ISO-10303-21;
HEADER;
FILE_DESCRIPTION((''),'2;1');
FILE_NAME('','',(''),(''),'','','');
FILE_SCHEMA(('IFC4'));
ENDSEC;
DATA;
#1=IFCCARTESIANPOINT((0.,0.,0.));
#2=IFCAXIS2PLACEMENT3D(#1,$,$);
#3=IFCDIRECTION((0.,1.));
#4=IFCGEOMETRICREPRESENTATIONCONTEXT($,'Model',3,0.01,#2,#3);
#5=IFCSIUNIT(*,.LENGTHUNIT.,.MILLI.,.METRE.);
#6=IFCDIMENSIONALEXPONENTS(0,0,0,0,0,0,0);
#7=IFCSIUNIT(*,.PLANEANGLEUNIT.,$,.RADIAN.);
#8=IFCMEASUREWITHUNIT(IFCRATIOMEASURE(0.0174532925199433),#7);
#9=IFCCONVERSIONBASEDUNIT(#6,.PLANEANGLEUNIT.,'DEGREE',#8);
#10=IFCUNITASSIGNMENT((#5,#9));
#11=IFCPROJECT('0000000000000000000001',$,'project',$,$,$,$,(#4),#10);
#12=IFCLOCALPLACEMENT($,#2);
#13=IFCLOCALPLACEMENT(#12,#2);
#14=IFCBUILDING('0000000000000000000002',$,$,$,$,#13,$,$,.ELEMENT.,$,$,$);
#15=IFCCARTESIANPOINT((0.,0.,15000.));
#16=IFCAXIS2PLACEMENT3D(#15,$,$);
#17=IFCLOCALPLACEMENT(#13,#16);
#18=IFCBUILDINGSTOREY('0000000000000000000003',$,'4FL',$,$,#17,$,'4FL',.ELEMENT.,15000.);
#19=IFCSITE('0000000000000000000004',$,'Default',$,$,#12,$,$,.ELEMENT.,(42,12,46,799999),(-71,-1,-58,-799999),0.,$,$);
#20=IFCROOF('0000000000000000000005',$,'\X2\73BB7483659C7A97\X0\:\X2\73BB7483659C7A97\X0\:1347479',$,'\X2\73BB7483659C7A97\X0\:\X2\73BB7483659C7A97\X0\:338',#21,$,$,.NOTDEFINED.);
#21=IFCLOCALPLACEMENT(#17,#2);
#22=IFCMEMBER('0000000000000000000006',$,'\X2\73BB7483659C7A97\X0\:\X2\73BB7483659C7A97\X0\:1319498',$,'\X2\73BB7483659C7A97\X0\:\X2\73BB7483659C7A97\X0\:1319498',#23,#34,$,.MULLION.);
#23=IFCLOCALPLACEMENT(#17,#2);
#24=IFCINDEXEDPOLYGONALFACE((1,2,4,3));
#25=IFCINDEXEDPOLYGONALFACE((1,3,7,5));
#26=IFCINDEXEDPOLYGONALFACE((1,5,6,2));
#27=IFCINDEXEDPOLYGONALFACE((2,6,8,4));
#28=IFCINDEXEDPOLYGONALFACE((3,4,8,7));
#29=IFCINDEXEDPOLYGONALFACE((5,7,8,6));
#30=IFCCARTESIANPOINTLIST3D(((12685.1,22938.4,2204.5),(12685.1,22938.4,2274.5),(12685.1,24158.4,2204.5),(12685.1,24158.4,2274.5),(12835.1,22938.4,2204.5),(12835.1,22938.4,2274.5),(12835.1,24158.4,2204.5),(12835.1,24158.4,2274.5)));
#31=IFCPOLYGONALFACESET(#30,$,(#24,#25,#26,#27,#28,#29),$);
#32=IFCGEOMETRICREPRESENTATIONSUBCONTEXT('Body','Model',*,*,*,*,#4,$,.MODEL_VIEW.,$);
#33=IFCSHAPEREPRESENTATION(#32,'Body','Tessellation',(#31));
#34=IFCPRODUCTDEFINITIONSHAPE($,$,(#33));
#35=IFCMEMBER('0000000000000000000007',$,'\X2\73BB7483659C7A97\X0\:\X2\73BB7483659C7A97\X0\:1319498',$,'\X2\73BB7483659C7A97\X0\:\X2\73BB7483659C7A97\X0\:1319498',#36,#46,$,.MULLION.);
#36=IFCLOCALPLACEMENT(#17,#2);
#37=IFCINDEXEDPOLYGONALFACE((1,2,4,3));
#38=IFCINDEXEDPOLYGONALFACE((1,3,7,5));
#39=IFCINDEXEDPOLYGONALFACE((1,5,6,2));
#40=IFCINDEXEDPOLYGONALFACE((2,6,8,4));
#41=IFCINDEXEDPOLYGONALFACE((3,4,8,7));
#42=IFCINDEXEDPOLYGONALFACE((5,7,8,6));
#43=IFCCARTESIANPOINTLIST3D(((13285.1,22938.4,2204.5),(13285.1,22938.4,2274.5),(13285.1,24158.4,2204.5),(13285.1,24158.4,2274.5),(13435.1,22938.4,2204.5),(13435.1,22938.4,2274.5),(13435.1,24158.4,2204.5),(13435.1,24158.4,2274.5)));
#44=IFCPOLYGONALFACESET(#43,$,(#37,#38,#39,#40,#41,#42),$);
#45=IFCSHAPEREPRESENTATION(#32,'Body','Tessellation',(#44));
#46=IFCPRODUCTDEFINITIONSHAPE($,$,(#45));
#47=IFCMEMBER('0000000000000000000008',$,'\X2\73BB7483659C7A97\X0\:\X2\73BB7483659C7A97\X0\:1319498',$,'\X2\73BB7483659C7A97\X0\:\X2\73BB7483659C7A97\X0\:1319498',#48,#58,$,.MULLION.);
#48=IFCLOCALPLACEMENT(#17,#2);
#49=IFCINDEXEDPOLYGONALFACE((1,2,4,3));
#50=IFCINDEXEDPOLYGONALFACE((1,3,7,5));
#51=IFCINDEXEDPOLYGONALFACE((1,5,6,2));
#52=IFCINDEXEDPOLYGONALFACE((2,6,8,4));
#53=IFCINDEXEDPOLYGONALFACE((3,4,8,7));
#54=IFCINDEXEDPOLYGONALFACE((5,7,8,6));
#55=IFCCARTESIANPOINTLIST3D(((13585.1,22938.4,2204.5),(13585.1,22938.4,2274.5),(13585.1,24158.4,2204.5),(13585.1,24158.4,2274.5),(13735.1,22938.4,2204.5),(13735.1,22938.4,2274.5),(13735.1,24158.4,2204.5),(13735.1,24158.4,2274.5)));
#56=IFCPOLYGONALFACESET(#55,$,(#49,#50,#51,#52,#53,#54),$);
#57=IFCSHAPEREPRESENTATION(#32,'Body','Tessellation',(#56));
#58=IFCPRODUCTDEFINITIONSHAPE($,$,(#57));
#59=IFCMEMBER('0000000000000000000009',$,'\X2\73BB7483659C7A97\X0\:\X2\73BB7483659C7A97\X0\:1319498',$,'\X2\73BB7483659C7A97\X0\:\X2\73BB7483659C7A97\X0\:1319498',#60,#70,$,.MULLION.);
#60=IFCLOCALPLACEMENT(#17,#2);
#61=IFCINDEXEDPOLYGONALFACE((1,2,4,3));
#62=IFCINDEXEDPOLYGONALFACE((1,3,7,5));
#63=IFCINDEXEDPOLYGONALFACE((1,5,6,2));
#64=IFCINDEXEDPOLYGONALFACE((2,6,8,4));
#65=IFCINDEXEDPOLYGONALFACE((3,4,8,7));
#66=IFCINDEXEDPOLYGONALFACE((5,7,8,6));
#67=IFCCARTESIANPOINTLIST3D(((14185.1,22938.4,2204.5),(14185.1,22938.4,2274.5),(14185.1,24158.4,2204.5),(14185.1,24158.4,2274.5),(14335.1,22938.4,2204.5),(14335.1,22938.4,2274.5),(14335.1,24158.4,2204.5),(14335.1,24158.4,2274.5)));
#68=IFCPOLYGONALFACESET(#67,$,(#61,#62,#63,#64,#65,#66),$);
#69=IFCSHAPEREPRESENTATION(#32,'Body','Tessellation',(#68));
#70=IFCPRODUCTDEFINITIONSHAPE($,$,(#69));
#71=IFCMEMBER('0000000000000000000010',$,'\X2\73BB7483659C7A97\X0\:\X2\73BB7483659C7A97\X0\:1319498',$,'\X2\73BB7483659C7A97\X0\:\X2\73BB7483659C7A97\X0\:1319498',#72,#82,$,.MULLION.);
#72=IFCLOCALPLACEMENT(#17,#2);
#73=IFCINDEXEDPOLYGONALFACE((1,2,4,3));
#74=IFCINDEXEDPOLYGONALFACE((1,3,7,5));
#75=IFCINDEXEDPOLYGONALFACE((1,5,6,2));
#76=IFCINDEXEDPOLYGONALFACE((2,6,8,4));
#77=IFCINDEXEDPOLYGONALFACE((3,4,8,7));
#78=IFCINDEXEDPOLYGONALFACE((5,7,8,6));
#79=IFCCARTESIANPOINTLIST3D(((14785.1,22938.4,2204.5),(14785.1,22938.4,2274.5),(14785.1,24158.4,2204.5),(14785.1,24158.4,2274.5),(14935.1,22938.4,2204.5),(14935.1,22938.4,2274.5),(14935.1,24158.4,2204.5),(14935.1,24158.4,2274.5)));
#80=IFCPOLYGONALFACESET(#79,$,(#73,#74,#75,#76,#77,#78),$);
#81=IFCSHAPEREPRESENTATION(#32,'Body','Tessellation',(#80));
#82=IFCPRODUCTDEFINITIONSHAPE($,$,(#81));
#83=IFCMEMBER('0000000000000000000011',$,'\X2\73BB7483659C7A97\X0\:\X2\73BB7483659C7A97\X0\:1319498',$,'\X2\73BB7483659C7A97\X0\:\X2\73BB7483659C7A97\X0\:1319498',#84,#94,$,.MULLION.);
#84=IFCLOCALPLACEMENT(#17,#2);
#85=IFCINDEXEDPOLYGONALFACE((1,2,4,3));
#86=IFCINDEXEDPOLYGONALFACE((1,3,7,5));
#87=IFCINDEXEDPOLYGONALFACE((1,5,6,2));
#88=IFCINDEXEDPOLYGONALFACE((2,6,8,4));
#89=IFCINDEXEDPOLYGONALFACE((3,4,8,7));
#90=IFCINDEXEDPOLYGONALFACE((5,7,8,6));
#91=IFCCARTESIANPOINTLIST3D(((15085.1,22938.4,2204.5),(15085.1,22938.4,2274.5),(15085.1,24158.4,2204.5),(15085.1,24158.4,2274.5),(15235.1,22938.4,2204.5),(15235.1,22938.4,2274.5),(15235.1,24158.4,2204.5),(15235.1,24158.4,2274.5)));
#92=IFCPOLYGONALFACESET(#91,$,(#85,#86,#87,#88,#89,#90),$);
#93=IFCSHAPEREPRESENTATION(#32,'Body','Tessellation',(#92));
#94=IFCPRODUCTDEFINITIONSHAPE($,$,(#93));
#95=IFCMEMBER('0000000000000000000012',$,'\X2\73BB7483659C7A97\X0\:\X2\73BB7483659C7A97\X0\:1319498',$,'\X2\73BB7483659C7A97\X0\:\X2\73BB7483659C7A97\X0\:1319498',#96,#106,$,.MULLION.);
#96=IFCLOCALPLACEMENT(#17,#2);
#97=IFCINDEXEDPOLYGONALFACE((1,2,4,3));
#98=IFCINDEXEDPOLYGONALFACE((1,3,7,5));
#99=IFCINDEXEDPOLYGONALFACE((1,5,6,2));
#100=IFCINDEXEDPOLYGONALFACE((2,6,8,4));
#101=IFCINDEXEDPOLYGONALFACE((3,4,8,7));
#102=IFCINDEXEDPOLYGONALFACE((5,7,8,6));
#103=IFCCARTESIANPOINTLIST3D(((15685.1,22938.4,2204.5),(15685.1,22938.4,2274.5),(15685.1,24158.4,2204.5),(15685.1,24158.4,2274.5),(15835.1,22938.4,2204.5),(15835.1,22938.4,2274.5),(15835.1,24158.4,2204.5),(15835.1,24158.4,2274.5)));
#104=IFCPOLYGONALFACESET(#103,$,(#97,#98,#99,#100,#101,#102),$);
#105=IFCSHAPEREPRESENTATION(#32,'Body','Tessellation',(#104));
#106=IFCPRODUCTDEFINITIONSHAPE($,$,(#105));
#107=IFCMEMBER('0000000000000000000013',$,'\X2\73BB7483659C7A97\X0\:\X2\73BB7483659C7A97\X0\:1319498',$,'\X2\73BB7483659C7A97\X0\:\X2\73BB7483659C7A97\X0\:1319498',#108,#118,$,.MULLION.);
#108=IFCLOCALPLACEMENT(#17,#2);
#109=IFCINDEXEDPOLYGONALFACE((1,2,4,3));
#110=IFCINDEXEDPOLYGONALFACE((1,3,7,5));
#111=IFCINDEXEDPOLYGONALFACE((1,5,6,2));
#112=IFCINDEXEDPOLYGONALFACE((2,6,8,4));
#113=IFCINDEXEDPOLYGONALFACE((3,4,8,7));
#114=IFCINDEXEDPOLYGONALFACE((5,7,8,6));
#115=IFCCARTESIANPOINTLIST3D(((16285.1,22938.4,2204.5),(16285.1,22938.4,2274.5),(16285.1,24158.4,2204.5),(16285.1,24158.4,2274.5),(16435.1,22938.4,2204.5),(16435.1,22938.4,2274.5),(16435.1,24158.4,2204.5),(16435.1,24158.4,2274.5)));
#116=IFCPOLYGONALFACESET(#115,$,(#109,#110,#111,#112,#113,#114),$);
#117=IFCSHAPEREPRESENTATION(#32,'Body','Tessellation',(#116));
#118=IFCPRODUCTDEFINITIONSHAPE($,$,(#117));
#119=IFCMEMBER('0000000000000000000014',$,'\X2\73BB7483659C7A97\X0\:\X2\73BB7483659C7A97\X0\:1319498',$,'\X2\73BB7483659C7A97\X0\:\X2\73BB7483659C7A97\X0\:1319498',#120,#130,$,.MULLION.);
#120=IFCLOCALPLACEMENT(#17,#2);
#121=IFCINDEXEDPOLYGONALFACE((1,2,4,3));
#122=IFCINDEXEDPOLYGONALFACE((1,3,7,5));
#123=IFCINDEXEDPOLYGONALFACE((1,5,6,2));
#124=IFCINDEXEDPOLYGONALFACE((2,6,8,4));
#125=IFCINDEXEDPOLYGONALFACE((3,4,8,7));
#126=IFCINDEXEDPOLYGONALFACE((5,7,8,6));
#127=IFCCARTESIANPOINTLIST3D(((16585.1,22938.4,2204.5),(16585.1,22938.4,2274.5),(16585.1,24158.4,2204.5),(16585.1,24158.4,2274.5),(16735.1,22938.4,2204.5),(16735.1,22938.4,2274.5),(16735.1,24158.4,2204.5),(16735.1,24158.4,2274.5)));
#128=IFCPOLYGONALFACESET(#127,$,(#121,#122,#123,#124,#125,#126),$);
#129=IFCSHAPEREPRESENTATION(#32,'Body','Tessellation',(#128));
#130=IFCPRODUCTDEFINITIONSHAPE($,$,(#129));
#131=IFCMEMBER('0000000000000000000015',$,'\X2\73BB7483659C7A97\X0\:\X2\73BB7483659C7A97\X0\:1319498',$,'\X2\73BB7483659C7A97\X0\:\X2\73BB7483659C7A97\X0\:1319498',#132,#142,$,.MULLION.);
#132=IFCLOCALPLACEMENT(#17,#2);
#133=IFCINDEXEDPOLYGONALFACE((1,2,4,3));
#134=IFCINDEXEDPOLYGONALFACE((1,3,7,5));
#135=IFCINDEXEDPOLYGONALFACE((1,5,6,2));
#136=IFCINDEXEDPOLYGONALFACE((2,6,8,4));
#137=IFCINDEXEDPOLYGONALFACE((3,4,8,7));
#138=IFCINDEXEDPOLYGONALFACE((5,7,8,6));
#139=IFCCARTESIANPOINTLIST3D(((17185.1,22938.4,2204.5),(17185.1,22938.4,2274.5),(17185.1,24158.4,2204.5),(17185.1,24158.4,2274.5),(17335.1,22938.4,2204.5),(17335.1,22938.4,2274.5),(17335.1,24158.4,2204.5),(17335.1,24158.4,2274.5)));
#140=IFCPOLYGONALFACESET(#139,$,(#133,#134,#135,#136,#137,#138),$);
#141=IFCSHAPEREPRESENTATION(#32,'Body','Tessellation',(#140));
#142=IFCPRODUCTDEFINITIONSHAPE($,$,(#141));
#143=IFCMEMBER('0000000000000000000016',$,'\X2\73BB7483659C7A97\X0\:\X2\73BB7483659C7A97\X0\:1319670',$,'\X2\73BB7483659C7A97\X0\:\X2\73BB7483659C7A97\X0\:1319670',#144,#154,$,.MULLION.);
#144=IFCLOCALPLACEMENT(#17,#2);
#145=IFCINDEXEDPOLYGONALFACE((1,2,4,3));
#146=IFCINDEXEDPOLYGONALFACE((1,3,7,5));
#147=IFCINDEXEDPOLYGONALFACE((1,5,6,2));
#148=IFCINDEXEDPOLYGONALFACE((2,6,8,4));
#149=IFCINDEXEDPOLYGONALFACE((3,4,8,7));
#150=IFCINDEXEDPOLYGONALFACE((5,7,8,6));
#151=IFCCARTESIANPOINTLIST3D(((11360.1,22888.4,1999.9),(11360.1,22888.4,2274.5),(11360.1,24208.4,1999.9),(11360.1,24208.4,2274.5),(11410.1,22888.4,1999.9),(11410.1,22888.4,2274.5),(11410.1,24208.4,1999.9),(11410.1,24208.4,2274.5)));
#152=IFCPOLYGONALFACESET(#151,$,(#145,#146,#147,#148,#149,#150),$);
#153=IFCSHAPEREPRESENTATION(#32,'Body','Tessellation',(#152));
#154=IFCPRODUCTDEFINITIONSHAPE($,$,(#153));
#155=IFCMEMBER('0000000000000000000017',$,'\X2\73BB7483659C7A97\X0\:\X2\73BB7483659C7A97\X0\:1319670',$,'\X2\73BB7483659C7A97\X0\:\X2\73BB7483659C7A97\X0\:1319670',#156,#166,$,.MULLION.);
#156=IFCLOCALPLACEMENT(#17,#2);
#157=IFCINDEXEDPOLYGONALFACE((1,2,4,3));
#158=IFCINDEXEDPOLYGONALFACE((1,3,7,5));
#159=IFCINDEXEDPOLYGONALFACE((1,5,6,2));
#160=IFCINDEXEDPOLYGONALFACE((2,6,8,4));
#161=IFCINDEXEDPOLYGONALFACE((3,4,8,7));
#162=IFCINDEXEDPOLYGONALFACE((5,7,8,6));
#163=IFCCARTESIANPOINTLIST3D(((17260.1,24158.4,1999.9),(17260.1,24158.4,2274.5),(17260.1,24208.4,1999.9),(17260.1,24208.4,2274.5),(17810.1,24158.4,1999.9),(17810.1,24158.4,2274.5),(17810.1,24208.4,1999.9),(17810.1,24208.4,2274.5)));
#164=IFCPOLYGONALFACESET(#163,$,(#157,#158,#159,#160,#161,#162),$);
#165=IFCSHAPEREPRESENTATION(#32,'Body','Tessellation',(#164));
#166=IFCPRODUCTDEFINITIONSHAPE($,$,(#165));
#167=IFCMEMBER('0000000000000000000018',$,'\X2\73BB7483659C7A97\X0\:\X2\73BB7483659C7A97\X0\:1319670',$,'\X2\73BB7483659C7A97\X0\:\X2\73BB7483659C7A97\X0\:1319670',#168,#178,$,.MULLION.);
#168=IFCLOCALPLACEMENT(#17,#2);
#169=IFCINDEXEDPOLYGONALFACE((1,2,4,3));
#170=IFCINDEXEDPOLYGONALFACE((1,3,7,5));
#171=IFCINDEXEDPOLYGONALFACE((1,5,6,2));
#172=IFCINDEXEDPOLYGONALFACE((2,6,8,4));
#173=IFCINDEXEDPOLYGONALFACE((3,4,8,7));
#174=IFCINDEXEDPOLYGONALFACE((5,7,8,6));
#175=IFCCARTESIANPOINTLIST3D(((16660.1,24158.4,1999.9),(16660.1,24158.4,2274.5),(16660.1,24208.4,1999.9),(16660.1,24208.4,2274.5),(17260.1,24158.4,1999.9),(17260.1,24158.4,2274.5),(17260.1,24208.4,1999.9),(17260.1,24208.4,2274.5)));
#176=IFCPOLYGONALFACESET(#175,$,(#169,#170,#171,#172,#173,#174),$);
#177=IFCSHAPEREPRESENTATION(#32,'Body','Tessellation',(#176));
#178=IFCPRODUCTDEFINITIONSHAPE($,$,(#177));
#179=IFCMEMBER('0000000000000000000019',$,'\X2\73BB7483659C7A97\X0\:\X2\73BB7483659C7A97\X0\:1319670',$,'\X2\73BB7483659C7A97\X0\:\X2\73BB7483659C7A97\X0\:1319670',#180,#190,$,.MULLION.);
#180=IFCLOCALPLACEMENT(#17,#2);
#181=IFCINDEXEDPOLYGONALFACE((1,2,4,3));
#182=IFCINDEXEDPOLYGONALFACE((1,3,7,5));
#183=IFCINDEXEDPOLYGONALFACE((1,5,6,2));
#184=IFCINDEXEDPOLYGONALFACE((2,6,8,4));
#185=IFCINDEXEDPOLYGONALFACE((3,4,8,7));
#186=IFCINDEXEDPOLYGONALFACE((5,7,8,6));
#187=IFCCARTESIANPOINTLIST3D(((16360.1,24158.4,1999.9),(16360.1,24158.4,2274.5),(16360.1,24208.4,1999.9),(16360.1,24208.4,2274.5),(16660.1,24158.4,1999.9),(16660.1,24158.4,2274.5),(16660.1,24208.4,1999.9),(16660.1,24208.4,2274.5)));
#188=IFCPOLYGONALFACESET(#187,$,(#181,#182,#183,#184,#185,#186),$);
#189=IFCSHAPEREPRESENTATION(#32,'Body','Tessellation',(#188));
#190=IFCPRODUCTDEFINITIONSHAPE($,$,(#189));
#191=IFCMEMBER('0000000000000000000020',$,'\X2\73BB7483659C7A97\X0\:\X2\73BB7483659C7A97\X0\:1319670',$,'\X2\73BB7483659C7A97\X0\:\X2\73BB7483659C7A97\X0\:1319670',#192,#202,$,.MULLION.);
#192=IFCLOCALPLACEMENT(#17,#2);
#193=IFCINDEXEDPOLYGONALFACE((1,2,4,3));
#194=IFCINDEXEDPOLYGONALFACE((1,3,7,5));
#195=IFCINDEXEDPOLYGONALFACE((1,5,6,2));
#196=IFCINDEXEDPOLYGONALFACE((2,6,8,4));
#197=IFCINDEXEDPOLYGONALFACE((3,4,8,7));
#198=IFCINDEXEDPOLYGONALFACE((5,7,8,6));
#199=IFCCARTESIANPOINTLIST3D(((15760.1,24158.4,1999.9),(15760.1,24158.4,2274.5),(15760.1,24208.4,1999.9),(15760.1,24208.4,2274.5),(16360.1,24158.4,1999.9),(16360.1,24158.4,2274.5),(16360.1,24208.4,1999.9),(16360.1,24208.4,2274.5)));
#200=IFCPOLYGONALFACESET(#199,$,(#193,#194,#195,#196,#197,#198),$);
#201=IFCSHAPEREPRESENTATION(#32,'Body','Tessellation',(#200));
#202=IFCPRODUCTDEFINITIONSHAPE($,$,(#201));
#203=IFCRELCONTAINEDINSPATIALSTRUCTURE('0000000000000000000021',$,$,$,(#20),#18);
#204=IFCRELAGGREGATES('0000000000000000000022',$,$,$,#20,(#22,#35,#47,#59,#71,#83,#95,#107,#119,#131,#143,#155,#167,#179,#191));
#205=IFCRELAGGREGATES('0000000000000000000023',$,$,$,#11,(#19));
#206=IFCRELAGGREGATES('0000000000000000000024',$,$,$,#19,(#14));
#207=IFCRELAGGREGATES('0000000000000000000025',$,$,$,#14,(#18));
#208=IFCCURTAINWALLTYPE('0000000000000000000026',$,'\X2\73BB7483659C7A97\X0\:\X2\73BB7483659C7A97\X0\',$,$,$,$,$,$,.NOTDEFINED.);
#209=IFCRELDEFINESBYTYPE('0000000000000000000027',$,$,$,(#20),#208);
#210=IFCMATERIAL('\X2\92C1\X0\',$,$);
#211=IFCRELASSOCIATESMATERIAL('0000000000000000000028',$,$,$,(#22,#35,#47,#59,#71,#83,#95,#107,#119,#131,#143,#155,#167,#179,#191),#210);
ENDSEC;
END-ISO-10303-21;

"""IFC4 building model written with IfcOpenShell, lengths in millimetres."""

from ifc_helpers import new_model, entity, si_unit, converted_unit, direction, frame, frame_2d, origin, place, context, subcontext, project, spatial, rectangle, extrude, material, type_object, element, aggregate, save


model = new_model("IFC4")

# Units and contexts
model_context = context("Model", 3, precision=0.01, world=origin(), true_north=direction((0.0, 1.0)))
body_context = subcontext(model_context, "Body", "Model", "MODEL_VIEW")
ifc_project = project(units=[si_unit("LENGTHUNIT", "METRE", prefix="MILLI"), converted_unit("PLANEANGLEUNIT", "DEGREE", entity("IfcRatioMeasure", 0.0174532925199433), si_unit("PLANEANGLEUNIT", "RADIAN"), dimensions=[0, 0, 0, 0, 0, 0, 0])], contexts=[model_context])

# Site, building, storey
site_placement = place(None, origin())
site = spatial("IfcSite", under=ifc_project, at=site_placement, Name="Default", CompositionType="ELEMENT", RefLatitude=(42, 12, 46, 799999), RefLongitude=(-71, -1, -58, -799999), RefElevation=0.0)
building_placement = place(site_placement, origin())
building = spatial("IfcBuilding", under=site, at=building_placement, CompositionType="ELEMENT")
storey_placement = place(building_placement, frame((0.0, 0.0, 15000.0)))
storey = spatial("IfcBuildingStorey", under=building, at=storey_placement, Name="4FL", LongName="4FL", CompositionType="ELEMENT", Elevation=15000.0)

# Roof, members
curtain_wall_type = type_object("IfcCurtainWallType", Name="玻璃斜窗:玻璃斜窗", PredefinedType="NOTDEFINED")
roof_1_placement = place(storey_placement, frame((0.0, 0.0, -15000.0)))
roof_1 = element("IfcRoof", 1, at=roof_1_placement, inside=storey, type_object=curtain_wall_type, Name="玻璃斜窗:玻璃斜窗:1347479", ObjectType="玻璃斜窗:玻璃斜窗:338", PredefinedType="NOTDEFINED")
ifc_material = material(Name="鋁")
member_1_placement = place(roof_1_placement, frame((0.0, 0.0, 15000.0)))
member_1 = element("IfcMember", 2, at=member_1_placement, material=ifc_material, Name="玻璃斜窗:玻璃斜窗:1319498", ObjectType="玻璃斜窗:玻璃斜窗:1319498", PredefinedType="MULLION", context=body_context, shape_type="SweptSolid", body=[
    extrude(rectangle(XDim=70.0, YDim=150.0, at=frame_2d((0.0, 0.0), x_axis=(1.0, 0.0))), frame((12760.1, 22938.4, 2239.5), z_axis=(0.0, 1.0, 0.0), x_axis=(0.0, 0.0, -1.0)), (0.0, 0.0, 1.0), 1220.0),
])
member_2_placement = place(roof_1_placement, frame((0.0, 0.0, 15000.0)))
member_2 = element("IfcMember", 3, at=member_2_placement, material=ifc_material, Name="玻璃斜窗:玻璃斜窗:1319498", ObjectType="玻璃斜窗:玻璃斜窗:1319498", PredefinedType="MULLION", context=body_context, shape_type="SweptSolid", body=[
    extrude(rectangle(XDim=70.0, YDim=150.0, at=frame_2d((0.0, 0.0), x_axis=(1.0, 0.0))), frame((13360.1, 22938.4, 2239.5), z_axis=(0.0, 1.0, 0.0), x_axis=(0.0, 0.0, -1.0)), (0.0, 0.0, 1.0), 1220.0),
])
member_3_placement = place(roof_1_placement, frame((0.0, 0.0, 15000.0)))
member_3 = element("IfcMember", 4, at=member_3_placement, material=ifc_material, Name="玻璃斜窗:玻璃斜窗:1319498", ObjectType="玻璃斜窗:玻璃斜窗:1319498", PredefinedType="MULLION", context=body_context, shape_type="SweptSolid", body=[
    extrude(rectangle(XDim=70.0, YDim=150.0, at=frame_2d((0.0, 0.0), x_axis=(1.0, 0.0))), frame((13660.1, 22938.4, 2239.5), z_axis=(0.0, 1.0, 0.0), x_axis=(0.0, 0.0, -1.0)), (0.0, 0.0, 1.0), 1220.0),
])
member_4_placement = place(roof_1_placement, frame((0.0, 0.0, 15000.0)))
member_4 = element("IfcMember", 5, at=member_4_placement, material=ifc_material, Name="玻璃斜窗:玻璃斜窗:1319498", ObjectType="玻璃斜窗:玻璃斜窗:1319498", PredefinedType="MULLION", context=body_context, shape_type="SweptSolid", body=[
    extrude(rectangle(XDim=70.0, YDim=150.0, at=frame_2d((0.0, 0.0), x_axis=(1.0, 0.0))), frame((14260.1, 22938.4, 2239.5), z_axis=(0.0, 1.0, 0.0), x_axis=(0.0, 0.0, -1.0)), (0.0, 0.0, 1.0), 1220.0),
])
member_5_placement = place(roof_1_placement, frame((0.0, 0.0, 15000.0)))
member_5 = element("IfcMember", 6, at=member_5_placement, material=ifc_material, Name="玻璃斜窗:玻璃斜窗:1319498", ObjectType="玻璃斜窗:玻璃斜窗:1319498", PredefinedType="MULLION", context=body_context, shape_type="SweptSolid", body=[
    extrude(rectangle(XDim=70.0, YDim=150.0, at=frame_2d((0.0, 0.0), x_axis=(1.0, 0.0))), frame((14860.1, 22938.4, 2239.5), z_axis=(0.0, 1.0, 0.0), x_axis=(0.0, 0.0, -1.0)), (0.0, 0.0, 1.0), 1220.0),
])
member_6_placement = place(roof_1_placement, frame((0.0, 0.0, 15000.0)))
member_6 = element("IfcMember", 7, at=member_6_placement, material=ifc_material, Name="玻璃斜窗:玻璃斜窗:1319498", ObjectType="玻璃斜窗:玻璃斜窗:1319498", PredefinedType="MULLION", context=body_context, shape_type="SweptSolid", body=[
    extrude(rectangle(XDim=70.0, YDim=150.0, at=frame_2d((0.0, 0.0), x_axis=(1.0, 0.0))), frame((15160.1, 22938.4, 2239.5), z_axis=(0.0, 1.0, 0.0), x_axis=(0.0, 0.0, -1.0)), (0.0, 0.0, 1.0), 1220.0),
])
member_7_placement = place(roof_1_placement, frame((0.0, 0.0, 15000.0)))
member_7 = element("IfcMember", 8, at=member_7_placement, material=ifc_material, Name="玻璃斜窗:玻璃斜窗:1319498", ObjectType="玻璃斜窗:玻璃斜窗:1319498", PredefinedType="MULLION", context=body_context, shape_type="SweptSolid", body=[
    extrude(rectangle(XDim=70.0, YDim=150.0, at=frame_2d((0.0, 0.0), x_axis=(1.0, 0.0))), frame((15760.1, 22938.4, 2239.5), z_axis=(0.0, 1.0, 0.0), x_axis=(0.0, 0.0, -1.0)), (0.0, 0.0, 1.0), 1220.0),
])
member_8_placement = place(roof_1_placement, frame((0.0, 0.0, 15000.0)))
member_8 = element("IfcMember", 9, at=member_8_placement, material=ifc_material, Name="玻璃斜窗:玻璃斜窗:1319498", ObjectType="玻璃斜窗:玻璃斜窗:1319498", PredefinedType="MULLION", context=body_context, shape_type="SweptSolid", body=[
    extrude(rectangle(XDim=70.0, YDim=150.0, at=frame_2d((0.0, 0.0), x_axis=(1.0, 0.0))), frame((16360.1, 22938.4, 2239.5), z_axis=(0.0, 1.0, 0.0), x_axis=(0.0, 0.0, -1.0)), (0.0, 0.0, 1.0), 1220.0),
])
member_9_placement = place(roof_1_placement, frame((0.0, 0.0, 15000.0)))
member_9 = element("IfcMember", 10, at=member_9_placement, material=ifc_material, Name="玻璃斜窗:玻璃斜窗:1319498", ObjectType="玻璃斜窗:玻璃斜窗:1319498", PredefinedType="MULLION", context=body_context, shape_type="SweptSolid", body=[
    extrude(rectangle(XDim=70.0, YDim=150.0, at=frame_2d((0.0, 0.0), x_axis=(1.0, 0.0))), frame((16660.1, 22938.4, 2239.5), z_axis=(0.0, 1.0, 0.0), x_axis=(0.0, 0.0, -1.0)), (0.0, 0.0, 1.0), 1220.0),
])
member_10_placement = place(roof_1_placement, frame((0.0, 0.0, 15000.0)))
member_10 = element("IfcMember", 11, at=member_10_placement, material=ifc_material, Name="玻璃斜窗:玻璃斜窗:1319498", ObjectType="玻璃斜窗:玻璃斜窗:1319498", PredefinedType="MULLION", context=body_context, shape_type="SweptSolid", body=[
    extrude(rectangle(XDim=70.0, YDim=150.0, at=frame_2d((0.0, 0.0), x_axis=(1.0, 0.0))), frame((17260.1, 22938.4, 2239.5), z_axis=(0.0, 1.0, 0.0), x_axis=(0.0, 0.0, -1.0)), (0.0, 0.0, 1.0), 1220.0),
])
member_11_placement = place(roof_1_placement, frame((0.0, 0.0, 15000.0)))
member_11 = element("IfcMember", 12, at=member_11_placement, material=ifc_material, Name="玻璃斜窗:玻璃斜窗:1319670", ObjectType="玻璃斜窗:玻璃斜窗:1319670", PredefinedType="MULLION", context=body_context, shape_type="SweptSolid", body=[
    extrude(rectangle(XDim=274.5, YDim=50.0, at=frame_2d((0.0, 0.0), x_axis=(1.0, 0.0))), frame((11385.1, 22888.4, 2137.2), z_axis=(0.0, 1.0, 0.0), x_axis=(0.0, 0.0, -1.0)), (0.0, 0.0, 1.0), 1320.0),
])
member_12_placement = place(roof_1_placement, frame((0.0, 0.0, 15000.0)))
member_12 = element("IfcMember", 13, at=member_12_placement, material=ifc_material, Name="玻璃斜窗:玻璃斜窗:1319670", ObjectType="玻璃斜窗:玻璃斜窗:1319670", PredefinedType="MULLION", context=body_context, shape_type="SweptSolid", body=[
    extrude(rectangle(XDim=274.5, YDim=50.0, at=frame_2d((0.0, 0.0), x_axis=(1.0, 0.0))), frame((17260.1, 24183.4, 2137.2), z_axis=(1.0, 0.0, 0.0), x_axis=(0.0, 0.0, -1.0)), (0.0, 0.0, 1.0), 550.0),
])
member_13_placement = place(roof_1_placement, frame((0.0, 0.0, 15000.0)))
member_13 = element("IfcMember", 14, at=member_13_placement, material=ifc_material, Name="玻璃斜窗:玻璃斜窗:1319670", ObjectType="玻璃斜窗:玻璃斜窗:1319670", PredefinedType="MULLION", context=body_context, shape_type="SweptSolid", body=[
    extrude(rectangle(XDim=274.5, YDim=50.0, at=frame_2d((0.0, 0.0), x_axis=(1.0, 0.0))), frame((16660.1, 24183.4, 2137.2), z_axis=(1.0, 0.0, 0.0), x_axis=(0.0, 0.0, -1.0)), (0.0, 0.0, 1.0), 600.0),
])
member_14_placement = place(roof_1_placement, frame((0.0, 0.0, 15000.0)))
member_14 = element("IfcMember", 15, at=member_14_placement, material=ifc_material, Name="玻璃斜窗:玻璃斜窗:1319670", ObjectType="玻璃斜窗:玻璃斜窗:1319670", PredefinedType="MULLION", context=body_context, shape_type="SweptSolid", body=[
    extrude(rectangle(XDim=274.5, YDim=50.0, at=frame_2d((0.0, 0.0), x_axis=(1.0, 0.0))), frame((16360.1, 24183.4, 2137.2), z_axis=(1.0, 0.0, 0.0), x_axis=(0.0, 0.0, -1.0)), (0.0, 0.0, 1.0), 300.0),
])
member_15_placement = place(roof_1_placement, frame((0.0, 0.0, 15000.0)))
member_15 = element("IfcMember", 16, at=member_15_placement, material=ifc_material, Name="玻璃斜窗:玻璃斜窗:1319670", ObjectType="玻璃斜窗:玻璃斜窗:1319670", PredefinedType="MULLION", context=body_context, shape_type="SweptSolid", body=[
    extrude(rectangle(XDim=274.5, YDim=50.0, at=frame_2d((0.0, 0.0), x_axis=(1.0, 0.0))), frame((15760.1, 24183.4, 2137.2), z_axis=(1.0, 0.0, 0.0), x_axis=(0.0, 0.0, -1.0)), (0.0, 0.0, 1.0), 600.0),
])
aggregate(roof_1, [member_1, member_2, member_3, member_4, member_5, member_6, member_7, member_8, member_9, member_10, member_11, member_12, member_13, member_14, member_15])

save(model, "model.ifc")
